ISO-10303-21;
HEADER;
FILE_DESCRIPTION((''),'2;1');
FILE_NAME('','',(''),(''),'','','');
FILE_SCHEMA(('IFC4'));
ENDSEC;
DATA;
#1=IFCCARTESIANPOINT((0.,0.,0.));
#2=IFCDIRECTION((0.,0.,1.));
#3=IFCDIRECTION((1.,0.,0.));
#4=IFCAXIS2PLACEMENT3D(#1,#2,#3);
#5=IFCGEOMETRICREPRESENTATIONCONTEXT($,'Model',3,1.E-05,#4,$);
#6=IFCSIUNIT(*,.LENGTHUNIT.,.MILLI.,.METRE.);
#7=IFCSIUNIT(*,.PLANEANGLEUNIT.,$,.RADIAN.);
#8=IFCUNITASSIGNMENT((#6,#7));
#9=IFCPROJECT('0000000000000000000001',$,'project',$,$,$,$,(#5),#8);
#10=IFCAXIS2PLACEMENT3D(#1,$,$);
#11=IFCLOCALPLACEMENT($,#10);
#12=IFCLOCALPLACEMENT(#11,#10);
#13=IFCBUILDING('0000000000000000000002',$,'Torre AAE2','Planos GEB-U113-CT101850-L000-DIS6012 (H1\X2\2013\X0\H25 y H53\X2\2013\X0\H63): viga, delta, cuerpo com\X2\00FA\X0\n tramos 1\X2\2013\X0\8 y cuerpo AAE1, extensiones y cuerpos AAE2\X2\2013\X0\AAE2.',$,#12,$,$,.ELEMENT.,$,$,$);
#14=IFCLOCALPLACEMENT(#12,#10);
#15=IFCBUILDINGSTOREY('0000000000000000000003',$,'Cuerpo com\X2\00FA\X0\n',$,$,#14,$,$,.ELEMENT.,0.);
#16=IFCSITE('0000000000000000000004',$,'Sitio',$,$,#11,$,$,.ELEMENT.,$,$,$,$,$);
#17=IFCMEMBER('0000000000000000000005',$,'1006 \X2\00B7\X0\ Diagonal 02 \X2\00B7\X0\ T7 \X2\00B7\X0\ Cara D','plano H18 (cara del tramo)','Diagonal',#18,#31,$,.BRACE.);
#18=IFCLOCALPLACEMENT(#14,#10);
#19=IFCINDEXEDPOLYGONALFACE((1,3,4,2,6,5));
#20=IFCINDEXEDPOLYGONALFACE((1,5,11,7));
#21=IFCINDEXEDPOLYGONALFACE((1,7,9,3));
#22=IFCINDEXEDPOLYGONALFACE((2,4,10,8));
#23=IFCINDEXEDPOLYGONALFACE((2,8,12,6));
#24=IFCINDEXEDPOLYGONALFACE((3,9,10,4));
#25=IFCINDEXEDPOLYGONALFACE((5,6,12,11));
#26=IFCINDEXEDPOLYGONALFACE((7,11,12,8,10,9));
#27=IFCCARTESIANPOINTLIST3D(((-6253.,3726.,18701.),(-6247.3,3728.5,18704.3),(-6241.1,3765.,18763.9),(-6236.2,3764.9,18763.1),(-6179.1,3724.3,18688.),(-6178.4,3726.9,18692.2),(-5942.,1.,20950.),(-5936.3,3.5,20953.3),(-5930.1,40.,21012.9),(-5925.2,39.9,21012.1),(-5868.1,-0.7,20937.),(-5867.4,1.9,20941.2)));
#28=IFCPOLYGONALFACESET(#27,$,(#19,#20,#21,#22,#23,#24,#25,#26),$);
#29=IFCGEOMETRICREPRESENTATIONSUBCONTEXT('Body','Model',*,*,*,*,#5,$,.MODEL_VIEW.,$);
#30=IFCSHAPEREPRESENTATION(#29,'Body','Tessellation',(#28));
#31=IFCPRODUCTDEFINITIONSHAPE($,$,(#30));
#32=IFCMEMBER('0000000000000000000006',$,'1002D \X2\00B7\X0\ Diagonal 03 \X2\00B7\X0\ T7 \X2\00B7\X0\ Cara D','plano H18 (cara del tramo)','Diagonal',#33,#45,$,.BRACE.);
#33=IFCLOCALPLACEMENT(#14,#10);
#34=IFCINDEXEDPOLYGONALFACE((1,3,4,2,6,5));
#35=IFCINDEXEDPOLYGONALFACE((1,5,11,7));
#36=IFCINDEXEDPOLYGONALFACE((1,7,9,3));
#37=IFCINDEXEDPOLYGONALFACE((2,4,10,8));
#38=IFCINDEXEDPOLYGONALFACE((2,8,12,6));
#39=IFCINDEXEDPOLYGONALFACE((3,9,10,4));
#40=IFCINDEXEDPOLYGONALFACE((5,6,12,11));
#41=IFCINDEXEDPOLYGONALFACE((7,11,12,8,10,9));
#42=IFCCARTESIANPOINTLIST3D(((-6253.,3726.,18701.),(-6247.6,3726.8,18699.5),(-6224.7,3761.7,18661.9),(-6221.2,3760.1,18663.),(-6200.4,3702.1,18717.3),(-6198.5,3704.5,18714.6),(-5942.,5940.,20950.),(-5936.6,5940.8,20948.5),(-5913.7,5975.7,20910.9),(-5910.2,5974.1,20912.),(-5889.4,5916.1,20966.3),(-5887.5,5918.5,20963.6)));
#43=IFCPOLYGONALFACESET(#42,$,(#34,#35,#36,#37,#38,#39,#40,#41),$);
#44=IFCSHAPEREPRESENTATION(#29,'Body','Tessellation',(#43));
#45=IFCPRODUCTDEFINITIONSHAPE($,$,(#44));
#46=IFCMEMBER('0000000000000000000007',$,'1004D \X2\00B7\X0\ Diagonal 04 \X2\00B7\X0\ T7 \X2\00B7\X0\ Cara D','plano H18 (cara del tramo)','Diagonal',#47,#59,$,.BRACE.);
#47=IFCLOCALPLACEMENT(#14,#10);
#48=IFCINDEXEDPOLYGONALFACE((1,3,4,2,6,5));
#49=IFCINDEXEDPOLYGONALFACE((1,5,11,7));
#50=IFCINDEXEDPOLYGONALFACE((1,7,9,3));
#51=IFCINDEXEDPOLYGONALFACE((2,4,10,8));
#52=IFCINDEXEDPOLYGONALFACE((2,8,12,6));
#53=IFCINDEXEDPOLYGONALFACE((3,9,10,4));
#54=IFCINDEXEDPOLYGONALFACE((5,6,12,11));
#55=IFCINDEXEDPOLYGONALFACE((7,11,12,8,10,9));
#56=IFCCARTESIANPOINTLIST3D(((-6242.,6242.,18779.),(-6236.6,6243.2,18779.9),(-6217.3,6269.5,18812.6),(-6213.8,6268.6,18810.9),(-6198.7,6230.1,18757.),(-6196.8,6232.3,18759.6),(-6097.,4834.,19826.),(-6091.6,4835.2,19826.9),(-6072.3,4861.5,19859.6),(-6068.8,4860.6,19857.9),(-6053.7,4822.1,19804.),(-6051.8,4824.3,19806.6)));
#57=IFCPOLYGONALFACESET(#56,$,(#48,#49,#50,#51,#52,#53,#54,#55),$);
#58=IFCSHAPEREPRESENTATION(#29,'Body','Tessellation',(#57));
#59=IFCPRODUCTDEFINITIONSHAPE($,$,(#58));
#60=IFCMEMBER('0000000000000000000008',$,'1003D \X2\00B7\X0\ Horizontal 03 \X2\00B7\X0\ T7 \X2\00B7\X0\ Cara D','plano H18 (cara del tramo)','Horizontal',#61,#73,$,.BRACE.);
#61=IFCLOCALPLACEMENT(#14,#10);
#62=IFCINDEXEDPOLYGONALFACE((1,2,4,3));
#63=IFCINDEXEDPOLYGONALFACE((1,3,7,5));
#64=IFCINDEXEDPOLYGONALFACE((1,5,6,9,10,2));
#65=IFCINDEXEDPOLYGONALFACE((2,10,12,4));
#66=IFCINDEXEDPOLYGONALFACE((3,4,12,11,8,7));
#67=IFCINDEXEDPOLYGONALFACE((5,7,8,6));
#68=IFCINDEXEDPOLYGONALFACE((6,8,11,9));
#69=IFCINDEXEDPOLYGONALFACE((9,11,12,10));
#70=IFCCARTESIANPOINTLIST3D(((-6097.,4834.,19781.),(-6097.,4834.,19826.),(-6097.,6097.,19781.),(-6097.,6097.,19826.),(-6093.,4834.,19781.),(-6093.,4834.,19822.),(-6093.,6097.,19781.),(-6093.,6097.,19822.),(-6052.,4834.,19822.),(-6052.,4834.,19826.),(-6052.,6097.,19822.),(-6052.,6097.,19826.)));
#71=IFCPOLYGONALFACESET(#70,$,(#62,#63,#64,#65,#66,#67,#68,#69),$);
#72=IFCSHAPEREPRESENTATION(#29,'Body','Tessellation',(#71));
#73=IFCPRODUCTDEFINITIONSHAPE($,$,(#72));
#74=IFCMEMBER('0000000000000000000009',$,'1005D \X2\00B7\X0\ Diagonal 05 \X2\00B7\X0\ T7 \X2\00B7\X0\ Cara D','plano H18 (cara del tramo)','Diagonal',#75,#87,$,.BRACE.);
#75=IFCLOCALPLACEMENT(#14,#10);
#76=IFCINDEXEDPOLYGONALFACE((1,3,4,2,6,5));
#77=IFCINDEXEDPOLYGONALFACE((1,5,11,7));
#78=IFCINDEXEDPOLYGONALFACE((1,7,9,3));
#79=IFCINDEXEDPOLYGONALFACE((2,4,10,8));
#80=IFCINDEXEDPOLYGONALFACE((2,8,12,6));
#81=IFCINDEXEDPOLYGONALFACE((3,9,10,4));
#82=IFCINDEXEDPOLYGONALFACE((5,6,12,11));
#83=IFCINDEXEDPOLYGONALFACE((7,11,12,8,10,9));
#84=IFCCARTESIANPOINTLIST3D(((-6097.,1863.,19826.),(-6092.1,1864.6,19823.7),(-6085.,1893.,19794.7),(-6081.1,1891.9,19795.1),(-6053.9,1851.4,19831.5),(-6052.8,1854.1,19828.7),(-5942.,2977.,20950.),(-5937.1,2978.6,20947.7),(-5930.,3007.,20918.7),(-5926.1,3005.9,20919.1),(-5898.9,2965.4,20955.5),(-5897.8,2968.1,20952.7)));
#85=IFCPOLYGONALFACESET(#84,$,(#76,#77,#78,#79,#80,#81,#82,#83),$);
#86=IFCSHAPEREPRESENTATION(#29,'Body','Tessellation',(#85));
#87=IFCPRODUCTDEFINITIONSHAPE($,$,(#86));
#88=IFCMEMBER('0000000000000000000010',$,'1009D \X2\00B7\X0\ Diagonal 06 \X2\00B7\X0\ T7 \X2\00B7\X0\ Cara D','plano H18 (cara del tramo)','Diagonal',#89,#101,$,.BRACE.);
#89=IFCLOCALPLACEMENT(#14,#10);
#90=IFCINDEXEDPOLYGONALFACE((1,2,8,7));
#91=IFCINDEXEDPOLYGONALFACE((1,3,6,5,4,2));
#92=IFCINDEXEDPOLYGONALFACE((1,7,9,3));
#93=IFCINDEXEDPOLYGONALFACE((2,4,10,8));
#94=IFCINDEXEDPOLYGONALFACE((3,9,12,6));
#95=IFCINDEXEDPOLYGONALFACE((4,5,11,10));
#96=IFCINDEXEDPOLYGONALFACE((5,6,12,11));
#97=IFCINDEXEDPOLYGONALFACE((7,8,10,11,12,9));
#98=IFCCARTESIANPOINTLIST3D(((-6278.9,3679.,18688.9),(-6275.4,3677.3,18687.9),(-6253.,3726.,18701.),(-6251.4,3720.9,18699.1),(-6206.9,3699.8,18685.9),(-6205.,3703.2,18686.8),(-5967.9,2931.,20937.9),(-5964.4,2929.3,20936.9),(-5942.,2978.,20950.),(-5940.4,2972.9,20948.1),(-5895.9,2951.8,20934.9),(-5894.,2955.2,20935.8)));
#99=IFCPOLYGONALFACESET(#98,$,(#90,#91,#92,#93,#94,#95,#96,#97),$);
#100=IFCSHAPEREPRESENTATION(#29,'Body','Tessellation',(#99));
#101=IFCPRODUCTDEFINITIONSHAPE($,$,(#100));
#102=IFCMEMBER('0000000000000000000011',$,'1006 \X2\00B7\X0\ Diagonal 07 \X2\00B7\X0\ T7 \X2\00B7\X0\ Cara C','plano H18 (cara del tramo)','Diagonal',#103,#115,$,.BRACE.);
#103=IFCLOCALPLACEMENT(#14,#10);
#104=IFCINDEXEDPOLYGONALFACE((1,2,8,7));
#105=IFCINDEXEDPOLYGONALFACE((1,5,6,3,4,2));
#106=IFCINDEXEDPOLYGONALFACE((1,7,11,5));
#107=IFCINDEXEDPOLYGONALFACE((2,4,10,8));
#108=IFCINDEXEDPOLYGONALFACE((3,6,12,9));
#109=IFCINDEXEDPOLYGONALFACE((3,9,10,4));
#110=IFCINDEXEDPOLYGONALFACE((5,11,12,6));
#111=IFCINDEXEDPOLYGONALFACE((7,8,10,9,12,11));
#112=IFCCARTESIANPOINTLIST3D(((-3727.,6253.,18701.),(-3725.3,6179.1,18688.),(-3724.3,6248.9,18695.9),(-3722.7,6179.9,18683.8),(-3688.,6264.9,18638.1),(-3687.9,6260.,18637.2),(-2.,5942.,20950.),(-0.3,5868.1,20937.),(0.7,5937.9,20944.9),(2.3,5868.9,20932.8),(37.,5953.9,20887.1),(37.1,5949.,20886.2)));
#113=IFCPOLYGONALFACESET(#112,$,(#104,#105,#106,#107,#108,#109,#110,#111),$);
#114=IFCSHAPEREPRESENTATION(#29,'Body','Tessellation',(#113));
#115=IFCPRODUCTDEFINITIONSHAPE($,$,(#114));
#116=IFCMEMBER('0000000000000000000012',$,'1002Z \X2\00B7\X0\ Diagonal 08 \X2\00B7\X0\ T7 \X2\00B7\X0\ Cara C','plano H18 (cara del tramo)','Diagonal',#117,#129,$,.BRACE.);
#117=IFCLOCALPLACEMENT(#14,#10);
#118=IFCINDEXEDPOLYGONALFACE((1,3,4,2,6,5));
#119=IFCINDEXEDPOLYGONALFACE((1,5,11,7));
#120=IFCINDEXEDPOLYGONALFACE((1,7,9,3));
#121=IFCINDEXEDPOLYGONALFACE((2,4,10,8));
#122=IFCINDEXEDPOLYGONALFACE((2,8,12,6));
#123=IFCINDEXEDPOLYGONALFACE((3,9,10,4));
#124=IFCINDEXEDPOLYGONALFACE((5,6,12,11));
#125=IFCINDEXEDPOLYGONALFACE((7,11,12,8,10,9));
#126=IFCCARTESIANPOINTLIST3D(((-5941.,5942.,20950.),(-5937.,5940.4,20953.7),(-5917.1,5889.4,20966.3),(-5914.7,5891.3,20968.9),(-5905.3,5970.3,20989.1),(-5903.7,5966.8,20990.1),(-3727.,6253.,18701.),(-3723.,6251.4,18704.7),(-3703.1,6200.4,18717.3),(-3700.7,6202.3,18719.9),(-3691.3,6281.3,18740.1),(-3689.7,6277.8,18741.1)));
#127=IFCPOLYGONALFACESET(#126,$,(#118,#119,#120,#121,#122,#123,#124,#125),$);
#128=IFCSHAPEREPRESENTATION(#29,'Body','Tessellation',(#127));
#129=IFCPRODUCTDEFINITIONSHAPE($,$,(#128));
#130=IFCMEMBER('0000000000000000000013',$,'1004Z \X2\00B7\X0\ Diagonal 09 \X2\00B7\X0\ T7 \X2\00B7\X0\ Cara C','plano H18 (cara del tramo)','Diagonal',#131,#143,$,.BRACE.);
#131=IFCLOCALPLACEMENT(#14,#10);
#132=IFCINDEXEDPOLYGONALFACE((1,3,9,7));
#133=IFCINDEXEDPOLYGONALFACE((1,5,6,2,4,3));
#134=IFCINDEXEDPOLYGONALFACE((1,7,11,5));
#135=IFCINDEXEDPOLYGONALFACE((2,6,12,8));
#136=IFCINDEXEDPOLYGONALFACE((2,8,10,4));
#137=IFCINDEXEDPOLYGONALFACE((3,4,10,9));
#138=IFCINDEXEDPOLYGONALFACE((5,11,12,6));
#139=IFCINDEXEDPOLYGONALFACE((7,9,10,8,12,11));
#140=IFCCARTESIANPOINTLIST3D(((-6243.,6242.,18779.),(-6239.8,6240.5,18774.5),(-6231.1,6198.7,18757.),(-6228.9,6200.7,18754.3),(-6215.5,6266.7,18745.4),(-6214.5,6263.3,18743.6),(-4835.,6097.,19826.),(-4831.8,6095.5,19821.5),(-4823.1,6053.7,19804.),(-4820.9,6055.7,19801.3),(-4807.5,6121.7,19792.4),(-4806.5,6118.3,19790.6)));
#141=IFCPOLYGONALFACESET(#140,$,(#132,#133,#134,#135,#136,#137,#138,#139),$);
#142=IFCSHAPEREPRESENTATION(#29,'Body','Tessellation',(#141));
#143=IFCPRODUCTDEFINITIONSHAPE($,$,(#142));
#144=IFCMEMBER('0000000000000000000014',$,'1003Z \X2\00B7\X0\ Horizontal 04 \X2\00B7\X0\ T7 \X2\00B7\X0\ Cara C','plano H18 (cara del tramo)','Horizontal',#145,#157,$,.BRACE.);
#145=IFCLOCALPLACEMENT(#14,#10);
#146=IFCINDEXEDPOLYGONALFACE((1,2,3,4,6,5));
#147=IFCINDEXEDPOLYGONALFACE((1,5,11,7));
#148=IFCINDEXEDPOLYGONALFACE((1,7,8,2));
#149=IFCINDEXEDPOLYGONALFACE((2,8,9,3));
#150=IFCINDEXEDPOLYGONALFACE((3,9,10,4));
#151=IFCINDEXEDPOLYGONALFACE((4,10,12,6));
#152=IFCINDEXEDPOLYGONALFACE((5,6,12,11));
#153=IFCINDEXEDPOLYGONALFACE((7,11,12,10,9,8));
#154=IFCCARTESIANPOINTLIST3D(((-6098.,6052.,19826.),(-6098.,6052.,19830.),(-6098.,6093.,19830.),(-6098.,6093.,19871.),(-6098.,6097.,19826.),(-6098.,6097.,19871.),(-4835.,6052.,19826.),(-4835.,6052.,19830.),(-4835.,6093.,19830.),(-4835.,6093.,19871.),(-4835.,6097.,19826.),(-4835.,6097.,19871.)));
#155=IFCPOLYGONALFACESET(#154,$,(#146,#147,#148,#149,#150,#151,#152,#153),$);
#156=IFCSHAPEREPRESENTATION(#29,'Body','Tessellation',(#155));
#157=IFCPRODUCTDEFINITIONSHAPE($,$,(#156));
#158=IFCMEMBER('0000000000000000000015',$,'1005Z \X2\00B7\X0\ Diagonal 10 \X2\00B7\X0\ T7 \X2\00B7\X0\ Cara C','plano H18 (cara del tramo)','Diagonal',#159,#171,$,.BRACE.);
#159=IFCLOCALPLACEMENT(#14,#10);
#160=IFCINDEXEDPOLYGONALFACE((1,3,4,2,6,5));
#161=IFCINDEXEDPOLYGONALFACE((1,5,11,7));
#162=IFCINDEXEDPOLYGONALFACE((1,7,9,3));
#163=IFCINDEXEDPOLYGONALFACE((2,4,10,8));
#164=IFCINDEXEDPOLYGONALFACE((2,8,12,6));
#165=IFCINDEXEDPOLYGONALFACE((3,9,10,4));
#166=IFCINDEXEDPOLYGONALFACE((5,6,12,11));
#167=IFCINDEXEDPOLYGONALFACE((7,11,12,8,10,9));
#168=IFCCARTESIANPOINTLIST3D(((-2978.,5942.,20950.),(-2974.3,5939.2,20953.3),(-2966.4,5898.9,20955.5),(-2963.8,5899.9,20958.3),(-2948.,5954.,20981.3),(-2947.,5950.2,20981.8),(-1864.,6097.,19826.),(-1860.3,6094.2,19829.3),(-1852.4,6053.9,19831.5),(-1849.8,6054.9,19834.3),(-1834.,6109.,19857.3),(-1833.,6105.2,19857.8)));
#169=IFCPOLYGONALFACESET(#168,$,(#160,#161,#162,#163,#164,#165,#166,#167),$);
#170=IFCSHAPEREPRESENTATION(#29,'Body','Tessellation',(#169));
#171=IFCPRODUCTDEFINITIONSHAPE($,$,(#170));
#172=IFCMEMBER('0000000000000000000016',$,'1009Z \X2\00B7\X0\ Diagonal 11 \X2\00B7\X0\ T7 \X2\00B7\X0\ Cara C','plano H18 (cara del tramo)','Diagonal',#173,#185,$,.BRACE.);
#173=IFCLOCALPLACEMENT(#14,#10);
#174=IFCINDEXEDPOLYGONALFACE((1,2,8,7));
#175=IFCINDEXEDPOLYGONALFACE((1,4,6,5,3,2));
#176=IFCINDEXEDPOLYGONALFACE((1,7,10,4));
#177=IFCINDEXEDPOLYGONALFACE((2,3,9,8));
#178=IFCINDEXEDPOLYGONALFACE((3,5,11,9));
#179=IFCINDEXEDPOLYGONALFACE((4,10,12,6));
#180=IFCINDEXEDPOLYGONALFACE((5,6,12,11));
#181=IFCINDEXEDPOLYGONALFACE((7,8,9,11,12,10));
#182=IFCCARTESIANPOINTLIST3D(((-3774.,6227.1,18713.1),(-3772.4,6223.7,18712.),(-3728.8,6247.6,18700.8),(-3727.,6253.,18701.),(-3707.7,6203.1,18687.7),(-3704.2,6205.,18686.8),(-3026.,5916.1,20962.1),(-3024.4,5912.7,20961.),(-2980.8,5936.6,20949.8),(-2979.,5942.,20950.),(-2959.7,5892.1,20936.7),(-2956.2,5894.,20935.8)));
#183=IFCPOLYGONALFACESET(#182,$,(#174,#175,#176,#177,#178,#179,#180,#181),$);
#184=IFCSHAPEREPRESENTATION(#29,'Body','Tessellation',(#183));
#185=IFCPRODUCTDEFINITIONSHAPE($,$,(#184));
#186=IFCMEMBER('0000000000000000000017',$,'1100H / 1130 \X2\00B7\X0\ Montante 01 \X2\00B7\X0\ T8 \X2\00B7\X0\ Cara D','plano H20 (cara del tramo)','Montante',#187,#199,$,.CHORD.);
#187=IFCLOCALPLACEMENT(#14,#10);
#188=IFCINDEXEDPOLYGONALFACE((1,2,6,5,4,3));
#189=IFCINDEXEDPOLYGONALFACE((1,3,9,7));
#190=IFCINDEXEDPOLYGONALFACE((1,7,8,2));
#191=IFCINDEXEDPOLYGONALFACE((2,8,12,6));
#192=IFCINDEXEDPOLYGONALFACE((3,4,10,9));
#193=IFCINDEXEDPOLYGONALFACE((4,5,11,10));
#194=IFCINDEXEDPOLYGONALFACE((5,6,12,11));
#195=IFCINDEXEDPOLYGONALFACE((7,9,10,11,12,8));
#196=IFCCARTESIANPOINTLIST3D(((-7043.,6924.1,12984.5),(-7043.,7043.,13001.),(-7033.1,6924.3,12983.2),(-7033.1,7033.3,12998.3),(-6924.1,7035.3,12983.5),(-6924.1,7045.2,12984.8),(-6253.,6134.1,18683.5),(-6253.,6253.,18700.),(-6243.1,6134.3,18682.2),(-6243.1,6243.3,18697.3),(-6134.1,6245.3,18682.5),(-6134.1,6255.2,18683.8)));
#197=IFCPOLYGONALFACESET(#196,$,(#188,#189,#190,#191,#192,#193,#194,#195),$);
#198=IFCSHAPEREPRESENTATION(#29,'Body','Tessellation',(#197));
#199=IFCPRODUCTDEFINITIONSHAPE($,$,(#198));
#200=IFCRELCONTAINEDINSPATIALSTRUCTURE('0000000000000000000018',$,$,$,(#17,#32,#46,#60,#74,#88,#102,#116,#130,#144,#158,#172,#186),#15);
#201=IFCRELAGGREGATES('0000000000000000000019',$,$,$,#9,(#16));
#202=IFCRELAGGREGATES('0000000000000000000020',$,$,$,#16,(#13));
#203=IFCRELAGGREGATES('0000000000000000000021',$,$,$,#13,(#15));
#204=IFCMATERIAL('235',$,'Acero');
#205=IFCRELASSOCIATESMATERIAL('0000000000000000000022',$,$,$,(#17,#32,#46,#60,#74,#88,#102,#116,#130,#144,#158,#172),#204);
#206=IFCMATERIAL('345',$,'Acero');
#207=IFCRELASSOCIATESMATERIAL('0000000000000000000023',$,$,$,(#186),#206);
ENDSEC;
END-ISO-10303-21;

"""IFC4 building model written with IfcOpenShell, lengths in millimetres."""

from ifc_helpers import new_model, si_unit, frame, frame_2d, origin, origin_with_axes, place, context, subcontext, project, spatial, l_section, extrude, material, element, save


model = new_model("IFC4")

# Units and contexts
model_context = context("Model", 3, precision=1e-05, world=origin_with_axes())
body_context = subcontext(model_context, "Body", "Model", "MODEL_VIEW")
ifc_project = project(units=[si_unit("LENGTHUNIT", "METRE", prefix="MILLI"), si_unit("PLANEANGLEUNIT", "RADIAN")], contexts=[model_context])

# Site, building, storey
site_placement = place(None, origin())
site = spatial("IfcSite", under=ifc_project, at=site_placement, Name="Sitio", CompositionType="ELEMENT")
building_placement = place(site_placement, origin())
building = spatial("IfcBuilding", under=site, at=building_placement, Name="Torre AAE2", Description="Planos GEB-U113-CT101850-L000-DIS6012 (H1–H25 y H53–H63): viga, delta, cuerpo común tramos 1–8 y cuerpo AAE1, extensiones y cuerpos AAE2–AAE2.", CompositionType="ELEMENT")
storey_placement = place(building_placement, origin())
storey = spatial("IfcBuildingStorey", under=building, at=storey_placement, Name="Cuerpo común", CompositionType="ELEMENT", Elevation=0.0)

# Members
ifc_material_1 = material(Name="235", Category="Acero")
ifc_material_2 = material(Name="345", Category="Acero")
member_1_placement = place(storey_placement, frame((-6253.0, 3726.0, 18701.0), z_axis=(0.071291, -0.853892, 0.515544), x_axis=(0.984715, -0.022095, -0.172766)))
element("IfcMember", 1, at=member_1_placement, inside=storey, material=ifc_material_1, Name="1006 · Diagonal 02 · T7 · Cara D", Description="plano H18 (cara del tramo)", ObjectType="Diagonal", PredefinedType="BRACE", context=body_context, shape_type="SweptSolid", body=[
    extrude(l_section(Depth=75.0, Width=75.0, Thickness=5.0, at=frame_2d((37.5, 37.5))), None, (0.0, 0.0, 1.0), 4362.4),
])
member_2_placement = place(storey_placement, frame((-6253.0, 3726.0, 18701.0), z_axis=(0.09807, 0.698158, 0.709195), x_axis=(0.876361, -0.398265, 0.270881)))
element("IfcMember", 2, at=member_2_placement, inside=storey, material=ifc_material_1, Name="1002D · Diagonal 03 · T7 · Cara D", Description="plano H18 (cara del tramo)", ObjectType="Diagonal", PredefinedType="BRACE", context=body_context, shape_type="SweptSolid", body=[
    extrude(l_section(Depth=60.0, Width=60.0, Thickness=4.0, at=frame_2d((30.0, 30.0))), None, (0.0, 0.0, 1.0), 3171.2),
])
member_3_placement = place(storey_placement, frame((-6242.0, 6242.0, 18779.0), z_axis=(0.082358, -0.799729, 0.594685), x_axis=(0.865275, -0.238691, -0.440823)))
element("IfcMember", 3, at=member_3_placement, inside=storey, material=ifc_material_1, Name="1004D · Diagonal 04 · T7 · Cara D", Description="plano H18 (cara del tramo)", ObjectType="Diagonal", PredefinedType="BRACE", context=body_context, shape_type="SweptSolid", body=[
    extrude(l_section(Depth=50.0, Width=50.0, Thickness=4.0, at=frame_2d((25.0, 25.0))), None, (0.0, 0.0, 1.0), 1760.6),
])
member_4_placement = place(storey_placement, frame((-6097.0, 4834.0, 19826.0), z_axis=(0.0, 1.0, 0.0), x_axis=(1.0, 0.0, 0.0)))
element("IfcMember", 4, at=member_4_placement, inside=storey, material=ifc_material_1, Name="1003D · Horizontal 03 · T7 · Cara D", Description="plano H18 (cara del tramo)", ObjectType="Horizontal", PredefinedType="BRACE", context=body_context, shape_type="SweptSolid", body=[
    extrude(l_section(Depth=45.0, Width=45.0, Thickness=4.0, at=frame_2d((22.5, 22.5))), None, (0.0, 0.0, 1.0), 1263.0),
])
member_5_placement = place(storey_placement, frame((-6097.0, 1863.0, 19826.0), z_axis=(0.097479, 0.700588, 0.706877), x_axis=(0.958584, -0.257073, 0.122597)))
element("IfcMember", 5, at=member_5_placement, inside=storey, material=ifc_material_1, Name="1005D · Diagonal 05 · T7 · Cara D", Description="plano H18 (cara del tramo)", ObjectType="Diagonal", PredefinedType="BRACE", context=body_context, shape_type="SweptSolid", body=[
    extrude(l_section(Depth=45.0, Width=45.0, Thickness=4.0, at=frame_2d((22.5, 22.5))), None, (0.0, 0.0, 1.0), 1590.1),
])
member_6_placement = place(storey_placement, frame((-5942.0, 2978.0, 20950.0), z_axis=(-0.130101, 0.312912, -0.940829), x_axis=(0.873022, -0.413656, -0.258304)))
element("IfcMember", 6, at=member_6_placement, inside=storey, material=ifc_material_1, Name="1009D · Diagonal 06 · T7 · Cara D", Description="plano H18 (cara del tramo)", ObjectType="Diagonal", PredefinedType="BRACE", context=body_context, shape_type="SweptSolid", body=[
    extrude(l_section(Depth=55.0, Width=55.0, Thickness=4.0, at=frame_2d((27.5, 27.5))), None, (0.0, 0.0, 1.0), 2390.4),
])
member_7_placement = place(storey_placement, frame((-3727.0, 6253.0, 18701.0), z_axis=(0.853892, -0.071291, 0.515544), x_axis=(0.02214, -0.984701, -0.172839)))
element("IfcMember", 7, at=member_7_placement, inside=storey, material=ifc_material_1, Name="1006 · Diagonal 07 · T7 · Cara C", Description="plano H18 (cara del tramo)", ObjectType="Diagonal", PredefinedType="BRACE", context=body_context, shape_type="SweptSolid", body=[
    extrude(l_section(Depth=75.0, Width=75.0, Thickness=5.0, at=frame_2d((37.5, 37.5))), None, (0.0, 0.0, 1.0), 4362.4),
])
member_8_placement = place(storey_placement, frame((-3727.0, 6253.0, 18701.0), z_axis=(-0.698158, -0.09807, 0.709195), x_axis=(0.398314, -0.876322, 0.270934)))
element("IfcMember", 8, at=member_8_placement, inside=storey, material=ifc_material_1, Name="1002Z · Diagonal 08 · T7 · Cara C", Description="plano H18 (cara del tramo)", ObjectType="Diagonal", PredefinedType="BRACE", context=body_context, shape_type="SweptSolid", body=[
    extrude(l_section(Depth=60.0, Width=60.0, Thickness=4.0, at=frame_2d((30.0, 30.0))), None, (0.0, 0.0, 1.0), 3171.2),
])
member_9_placement = place(storey_placement, frame((-6243.0, 6242.0, 18779.0), z_axis=(0.799729, -0.082358, 0.594685), x_axis=(0.238737, -0.865234, -0.440879)))
element("IfcMember", 9, at=member_9_placement, inside=storey, material=ifc_material_1, Name="1004Z · Diagonal 09 · T7 · Cara C", Description="plano H18 (cara del tramo)", ObjectType="Diagonal", PredefinedType="BRACE", context=body_context, shape_type="SweptSolid", body=[
    extrude(l_section(Depth=50.0, Width=50.0, Thickness=4.0, at=frame_2d((25.0, 25.0))), None, (0.0, 0.0, 1.0), 1760.6),
])
member_10_placement = place(storey_placement, frame((-4835.0, 6097.0, 19826.0), z_axis=(-1.0, 0.0, 0.0), x_axis=(0.0, -1.0, 0.0)))
element("IfcMember", 10, at=member_10_placement, inside=storey, material=ifc_material_1, Name="1003Z · Horizontal 04 · T7 · Cara C", Description="plano H18 (cara del tramo)", ObjectType="Horizontal", PredefinedType="BRACE", context=body_context, shape_type="SweptSolid", body=[
    extrude(l_section(Depth=45.0, Width=45.0, Thickness=4.0, at=frame_2d((22.5, 22.5))), None, (0.0, 0.0, 1.0), 1263.0),
])
member_11_placement = place(storey_placement, frame((-1864.0, 6097.0, 19826.0), z_axis=(-0.700588, -0.097479, 0.706877), x_axis=(0.257143, -0.958556, 0.12267)))
element("IfcMember", 11, at=member_11_placement, inside=storey, material=ifc_material_1, Name="1005Z · Diagonal 10 · T7 · Cara C", Description="plano H18 (cara del tramo)", ObjectType="Diagonal", PredefinedType="BRACE", context=body_context, shape_type="SweptSolid", body=[
    extrude(l_section(Depth=45.0, Width=45.0, Thickness=4.0, at=frame_2d((22.5, 22.5))), None, (0.0, 0.0, 1.0), 1590.1),
])
member_12_placement = place(storey_placement, frame((-2979.0, 5942.0, 20950.0), z_axis=(-0.312912, 0.130101, -0.940829), x_axis=(0.413765, -0.872962, -0.258331)))
element("IfcMember", 12, at=member_12_placement, inside=storey, material=ifc_material_1, Name="1009Z · Diagonal 11 · T7 · Cara C", Description="plano H18 (cara del tramo)", ObjectType="Diagonal", PredefinedType="BRACE", context=body_context, shape_type="SweptSolid", body=[
    extrude(l_section(Depth=55.0, Width=55.0, Thickness=4.0, at=frame_2d((27.5, 27.5))), None, (0.0, 0.0, 1.0), 2390.4),
])
member_13_placement = place(storey_placement, frame((-6253.0, 6253.0, 18700.0), z_axis=(-0.136032, 0.136032, -0.981321), x_axis=(0.990705, 0.018678, -0.134743)))
element("IfcMember", 13, at=member_13_placement, inside=storey, material=ifc_material_2, Name="1100H / 1130 · Montante 01 · T8 · Cara D", Description="plano H20 (cara del tramo)", ObjectType="Montante", PredefinedType="CHORD", context=body_context, shape_type="SweptSolid", body=[
    extrude(l_section(Depth=120.0, Width=120.0, Thickness=10.0, at=frame_2d((60.0, 60.0))), None, (0.0, 0.0, 1.0), 5807.5),
])

save(model, "model.ifc")
